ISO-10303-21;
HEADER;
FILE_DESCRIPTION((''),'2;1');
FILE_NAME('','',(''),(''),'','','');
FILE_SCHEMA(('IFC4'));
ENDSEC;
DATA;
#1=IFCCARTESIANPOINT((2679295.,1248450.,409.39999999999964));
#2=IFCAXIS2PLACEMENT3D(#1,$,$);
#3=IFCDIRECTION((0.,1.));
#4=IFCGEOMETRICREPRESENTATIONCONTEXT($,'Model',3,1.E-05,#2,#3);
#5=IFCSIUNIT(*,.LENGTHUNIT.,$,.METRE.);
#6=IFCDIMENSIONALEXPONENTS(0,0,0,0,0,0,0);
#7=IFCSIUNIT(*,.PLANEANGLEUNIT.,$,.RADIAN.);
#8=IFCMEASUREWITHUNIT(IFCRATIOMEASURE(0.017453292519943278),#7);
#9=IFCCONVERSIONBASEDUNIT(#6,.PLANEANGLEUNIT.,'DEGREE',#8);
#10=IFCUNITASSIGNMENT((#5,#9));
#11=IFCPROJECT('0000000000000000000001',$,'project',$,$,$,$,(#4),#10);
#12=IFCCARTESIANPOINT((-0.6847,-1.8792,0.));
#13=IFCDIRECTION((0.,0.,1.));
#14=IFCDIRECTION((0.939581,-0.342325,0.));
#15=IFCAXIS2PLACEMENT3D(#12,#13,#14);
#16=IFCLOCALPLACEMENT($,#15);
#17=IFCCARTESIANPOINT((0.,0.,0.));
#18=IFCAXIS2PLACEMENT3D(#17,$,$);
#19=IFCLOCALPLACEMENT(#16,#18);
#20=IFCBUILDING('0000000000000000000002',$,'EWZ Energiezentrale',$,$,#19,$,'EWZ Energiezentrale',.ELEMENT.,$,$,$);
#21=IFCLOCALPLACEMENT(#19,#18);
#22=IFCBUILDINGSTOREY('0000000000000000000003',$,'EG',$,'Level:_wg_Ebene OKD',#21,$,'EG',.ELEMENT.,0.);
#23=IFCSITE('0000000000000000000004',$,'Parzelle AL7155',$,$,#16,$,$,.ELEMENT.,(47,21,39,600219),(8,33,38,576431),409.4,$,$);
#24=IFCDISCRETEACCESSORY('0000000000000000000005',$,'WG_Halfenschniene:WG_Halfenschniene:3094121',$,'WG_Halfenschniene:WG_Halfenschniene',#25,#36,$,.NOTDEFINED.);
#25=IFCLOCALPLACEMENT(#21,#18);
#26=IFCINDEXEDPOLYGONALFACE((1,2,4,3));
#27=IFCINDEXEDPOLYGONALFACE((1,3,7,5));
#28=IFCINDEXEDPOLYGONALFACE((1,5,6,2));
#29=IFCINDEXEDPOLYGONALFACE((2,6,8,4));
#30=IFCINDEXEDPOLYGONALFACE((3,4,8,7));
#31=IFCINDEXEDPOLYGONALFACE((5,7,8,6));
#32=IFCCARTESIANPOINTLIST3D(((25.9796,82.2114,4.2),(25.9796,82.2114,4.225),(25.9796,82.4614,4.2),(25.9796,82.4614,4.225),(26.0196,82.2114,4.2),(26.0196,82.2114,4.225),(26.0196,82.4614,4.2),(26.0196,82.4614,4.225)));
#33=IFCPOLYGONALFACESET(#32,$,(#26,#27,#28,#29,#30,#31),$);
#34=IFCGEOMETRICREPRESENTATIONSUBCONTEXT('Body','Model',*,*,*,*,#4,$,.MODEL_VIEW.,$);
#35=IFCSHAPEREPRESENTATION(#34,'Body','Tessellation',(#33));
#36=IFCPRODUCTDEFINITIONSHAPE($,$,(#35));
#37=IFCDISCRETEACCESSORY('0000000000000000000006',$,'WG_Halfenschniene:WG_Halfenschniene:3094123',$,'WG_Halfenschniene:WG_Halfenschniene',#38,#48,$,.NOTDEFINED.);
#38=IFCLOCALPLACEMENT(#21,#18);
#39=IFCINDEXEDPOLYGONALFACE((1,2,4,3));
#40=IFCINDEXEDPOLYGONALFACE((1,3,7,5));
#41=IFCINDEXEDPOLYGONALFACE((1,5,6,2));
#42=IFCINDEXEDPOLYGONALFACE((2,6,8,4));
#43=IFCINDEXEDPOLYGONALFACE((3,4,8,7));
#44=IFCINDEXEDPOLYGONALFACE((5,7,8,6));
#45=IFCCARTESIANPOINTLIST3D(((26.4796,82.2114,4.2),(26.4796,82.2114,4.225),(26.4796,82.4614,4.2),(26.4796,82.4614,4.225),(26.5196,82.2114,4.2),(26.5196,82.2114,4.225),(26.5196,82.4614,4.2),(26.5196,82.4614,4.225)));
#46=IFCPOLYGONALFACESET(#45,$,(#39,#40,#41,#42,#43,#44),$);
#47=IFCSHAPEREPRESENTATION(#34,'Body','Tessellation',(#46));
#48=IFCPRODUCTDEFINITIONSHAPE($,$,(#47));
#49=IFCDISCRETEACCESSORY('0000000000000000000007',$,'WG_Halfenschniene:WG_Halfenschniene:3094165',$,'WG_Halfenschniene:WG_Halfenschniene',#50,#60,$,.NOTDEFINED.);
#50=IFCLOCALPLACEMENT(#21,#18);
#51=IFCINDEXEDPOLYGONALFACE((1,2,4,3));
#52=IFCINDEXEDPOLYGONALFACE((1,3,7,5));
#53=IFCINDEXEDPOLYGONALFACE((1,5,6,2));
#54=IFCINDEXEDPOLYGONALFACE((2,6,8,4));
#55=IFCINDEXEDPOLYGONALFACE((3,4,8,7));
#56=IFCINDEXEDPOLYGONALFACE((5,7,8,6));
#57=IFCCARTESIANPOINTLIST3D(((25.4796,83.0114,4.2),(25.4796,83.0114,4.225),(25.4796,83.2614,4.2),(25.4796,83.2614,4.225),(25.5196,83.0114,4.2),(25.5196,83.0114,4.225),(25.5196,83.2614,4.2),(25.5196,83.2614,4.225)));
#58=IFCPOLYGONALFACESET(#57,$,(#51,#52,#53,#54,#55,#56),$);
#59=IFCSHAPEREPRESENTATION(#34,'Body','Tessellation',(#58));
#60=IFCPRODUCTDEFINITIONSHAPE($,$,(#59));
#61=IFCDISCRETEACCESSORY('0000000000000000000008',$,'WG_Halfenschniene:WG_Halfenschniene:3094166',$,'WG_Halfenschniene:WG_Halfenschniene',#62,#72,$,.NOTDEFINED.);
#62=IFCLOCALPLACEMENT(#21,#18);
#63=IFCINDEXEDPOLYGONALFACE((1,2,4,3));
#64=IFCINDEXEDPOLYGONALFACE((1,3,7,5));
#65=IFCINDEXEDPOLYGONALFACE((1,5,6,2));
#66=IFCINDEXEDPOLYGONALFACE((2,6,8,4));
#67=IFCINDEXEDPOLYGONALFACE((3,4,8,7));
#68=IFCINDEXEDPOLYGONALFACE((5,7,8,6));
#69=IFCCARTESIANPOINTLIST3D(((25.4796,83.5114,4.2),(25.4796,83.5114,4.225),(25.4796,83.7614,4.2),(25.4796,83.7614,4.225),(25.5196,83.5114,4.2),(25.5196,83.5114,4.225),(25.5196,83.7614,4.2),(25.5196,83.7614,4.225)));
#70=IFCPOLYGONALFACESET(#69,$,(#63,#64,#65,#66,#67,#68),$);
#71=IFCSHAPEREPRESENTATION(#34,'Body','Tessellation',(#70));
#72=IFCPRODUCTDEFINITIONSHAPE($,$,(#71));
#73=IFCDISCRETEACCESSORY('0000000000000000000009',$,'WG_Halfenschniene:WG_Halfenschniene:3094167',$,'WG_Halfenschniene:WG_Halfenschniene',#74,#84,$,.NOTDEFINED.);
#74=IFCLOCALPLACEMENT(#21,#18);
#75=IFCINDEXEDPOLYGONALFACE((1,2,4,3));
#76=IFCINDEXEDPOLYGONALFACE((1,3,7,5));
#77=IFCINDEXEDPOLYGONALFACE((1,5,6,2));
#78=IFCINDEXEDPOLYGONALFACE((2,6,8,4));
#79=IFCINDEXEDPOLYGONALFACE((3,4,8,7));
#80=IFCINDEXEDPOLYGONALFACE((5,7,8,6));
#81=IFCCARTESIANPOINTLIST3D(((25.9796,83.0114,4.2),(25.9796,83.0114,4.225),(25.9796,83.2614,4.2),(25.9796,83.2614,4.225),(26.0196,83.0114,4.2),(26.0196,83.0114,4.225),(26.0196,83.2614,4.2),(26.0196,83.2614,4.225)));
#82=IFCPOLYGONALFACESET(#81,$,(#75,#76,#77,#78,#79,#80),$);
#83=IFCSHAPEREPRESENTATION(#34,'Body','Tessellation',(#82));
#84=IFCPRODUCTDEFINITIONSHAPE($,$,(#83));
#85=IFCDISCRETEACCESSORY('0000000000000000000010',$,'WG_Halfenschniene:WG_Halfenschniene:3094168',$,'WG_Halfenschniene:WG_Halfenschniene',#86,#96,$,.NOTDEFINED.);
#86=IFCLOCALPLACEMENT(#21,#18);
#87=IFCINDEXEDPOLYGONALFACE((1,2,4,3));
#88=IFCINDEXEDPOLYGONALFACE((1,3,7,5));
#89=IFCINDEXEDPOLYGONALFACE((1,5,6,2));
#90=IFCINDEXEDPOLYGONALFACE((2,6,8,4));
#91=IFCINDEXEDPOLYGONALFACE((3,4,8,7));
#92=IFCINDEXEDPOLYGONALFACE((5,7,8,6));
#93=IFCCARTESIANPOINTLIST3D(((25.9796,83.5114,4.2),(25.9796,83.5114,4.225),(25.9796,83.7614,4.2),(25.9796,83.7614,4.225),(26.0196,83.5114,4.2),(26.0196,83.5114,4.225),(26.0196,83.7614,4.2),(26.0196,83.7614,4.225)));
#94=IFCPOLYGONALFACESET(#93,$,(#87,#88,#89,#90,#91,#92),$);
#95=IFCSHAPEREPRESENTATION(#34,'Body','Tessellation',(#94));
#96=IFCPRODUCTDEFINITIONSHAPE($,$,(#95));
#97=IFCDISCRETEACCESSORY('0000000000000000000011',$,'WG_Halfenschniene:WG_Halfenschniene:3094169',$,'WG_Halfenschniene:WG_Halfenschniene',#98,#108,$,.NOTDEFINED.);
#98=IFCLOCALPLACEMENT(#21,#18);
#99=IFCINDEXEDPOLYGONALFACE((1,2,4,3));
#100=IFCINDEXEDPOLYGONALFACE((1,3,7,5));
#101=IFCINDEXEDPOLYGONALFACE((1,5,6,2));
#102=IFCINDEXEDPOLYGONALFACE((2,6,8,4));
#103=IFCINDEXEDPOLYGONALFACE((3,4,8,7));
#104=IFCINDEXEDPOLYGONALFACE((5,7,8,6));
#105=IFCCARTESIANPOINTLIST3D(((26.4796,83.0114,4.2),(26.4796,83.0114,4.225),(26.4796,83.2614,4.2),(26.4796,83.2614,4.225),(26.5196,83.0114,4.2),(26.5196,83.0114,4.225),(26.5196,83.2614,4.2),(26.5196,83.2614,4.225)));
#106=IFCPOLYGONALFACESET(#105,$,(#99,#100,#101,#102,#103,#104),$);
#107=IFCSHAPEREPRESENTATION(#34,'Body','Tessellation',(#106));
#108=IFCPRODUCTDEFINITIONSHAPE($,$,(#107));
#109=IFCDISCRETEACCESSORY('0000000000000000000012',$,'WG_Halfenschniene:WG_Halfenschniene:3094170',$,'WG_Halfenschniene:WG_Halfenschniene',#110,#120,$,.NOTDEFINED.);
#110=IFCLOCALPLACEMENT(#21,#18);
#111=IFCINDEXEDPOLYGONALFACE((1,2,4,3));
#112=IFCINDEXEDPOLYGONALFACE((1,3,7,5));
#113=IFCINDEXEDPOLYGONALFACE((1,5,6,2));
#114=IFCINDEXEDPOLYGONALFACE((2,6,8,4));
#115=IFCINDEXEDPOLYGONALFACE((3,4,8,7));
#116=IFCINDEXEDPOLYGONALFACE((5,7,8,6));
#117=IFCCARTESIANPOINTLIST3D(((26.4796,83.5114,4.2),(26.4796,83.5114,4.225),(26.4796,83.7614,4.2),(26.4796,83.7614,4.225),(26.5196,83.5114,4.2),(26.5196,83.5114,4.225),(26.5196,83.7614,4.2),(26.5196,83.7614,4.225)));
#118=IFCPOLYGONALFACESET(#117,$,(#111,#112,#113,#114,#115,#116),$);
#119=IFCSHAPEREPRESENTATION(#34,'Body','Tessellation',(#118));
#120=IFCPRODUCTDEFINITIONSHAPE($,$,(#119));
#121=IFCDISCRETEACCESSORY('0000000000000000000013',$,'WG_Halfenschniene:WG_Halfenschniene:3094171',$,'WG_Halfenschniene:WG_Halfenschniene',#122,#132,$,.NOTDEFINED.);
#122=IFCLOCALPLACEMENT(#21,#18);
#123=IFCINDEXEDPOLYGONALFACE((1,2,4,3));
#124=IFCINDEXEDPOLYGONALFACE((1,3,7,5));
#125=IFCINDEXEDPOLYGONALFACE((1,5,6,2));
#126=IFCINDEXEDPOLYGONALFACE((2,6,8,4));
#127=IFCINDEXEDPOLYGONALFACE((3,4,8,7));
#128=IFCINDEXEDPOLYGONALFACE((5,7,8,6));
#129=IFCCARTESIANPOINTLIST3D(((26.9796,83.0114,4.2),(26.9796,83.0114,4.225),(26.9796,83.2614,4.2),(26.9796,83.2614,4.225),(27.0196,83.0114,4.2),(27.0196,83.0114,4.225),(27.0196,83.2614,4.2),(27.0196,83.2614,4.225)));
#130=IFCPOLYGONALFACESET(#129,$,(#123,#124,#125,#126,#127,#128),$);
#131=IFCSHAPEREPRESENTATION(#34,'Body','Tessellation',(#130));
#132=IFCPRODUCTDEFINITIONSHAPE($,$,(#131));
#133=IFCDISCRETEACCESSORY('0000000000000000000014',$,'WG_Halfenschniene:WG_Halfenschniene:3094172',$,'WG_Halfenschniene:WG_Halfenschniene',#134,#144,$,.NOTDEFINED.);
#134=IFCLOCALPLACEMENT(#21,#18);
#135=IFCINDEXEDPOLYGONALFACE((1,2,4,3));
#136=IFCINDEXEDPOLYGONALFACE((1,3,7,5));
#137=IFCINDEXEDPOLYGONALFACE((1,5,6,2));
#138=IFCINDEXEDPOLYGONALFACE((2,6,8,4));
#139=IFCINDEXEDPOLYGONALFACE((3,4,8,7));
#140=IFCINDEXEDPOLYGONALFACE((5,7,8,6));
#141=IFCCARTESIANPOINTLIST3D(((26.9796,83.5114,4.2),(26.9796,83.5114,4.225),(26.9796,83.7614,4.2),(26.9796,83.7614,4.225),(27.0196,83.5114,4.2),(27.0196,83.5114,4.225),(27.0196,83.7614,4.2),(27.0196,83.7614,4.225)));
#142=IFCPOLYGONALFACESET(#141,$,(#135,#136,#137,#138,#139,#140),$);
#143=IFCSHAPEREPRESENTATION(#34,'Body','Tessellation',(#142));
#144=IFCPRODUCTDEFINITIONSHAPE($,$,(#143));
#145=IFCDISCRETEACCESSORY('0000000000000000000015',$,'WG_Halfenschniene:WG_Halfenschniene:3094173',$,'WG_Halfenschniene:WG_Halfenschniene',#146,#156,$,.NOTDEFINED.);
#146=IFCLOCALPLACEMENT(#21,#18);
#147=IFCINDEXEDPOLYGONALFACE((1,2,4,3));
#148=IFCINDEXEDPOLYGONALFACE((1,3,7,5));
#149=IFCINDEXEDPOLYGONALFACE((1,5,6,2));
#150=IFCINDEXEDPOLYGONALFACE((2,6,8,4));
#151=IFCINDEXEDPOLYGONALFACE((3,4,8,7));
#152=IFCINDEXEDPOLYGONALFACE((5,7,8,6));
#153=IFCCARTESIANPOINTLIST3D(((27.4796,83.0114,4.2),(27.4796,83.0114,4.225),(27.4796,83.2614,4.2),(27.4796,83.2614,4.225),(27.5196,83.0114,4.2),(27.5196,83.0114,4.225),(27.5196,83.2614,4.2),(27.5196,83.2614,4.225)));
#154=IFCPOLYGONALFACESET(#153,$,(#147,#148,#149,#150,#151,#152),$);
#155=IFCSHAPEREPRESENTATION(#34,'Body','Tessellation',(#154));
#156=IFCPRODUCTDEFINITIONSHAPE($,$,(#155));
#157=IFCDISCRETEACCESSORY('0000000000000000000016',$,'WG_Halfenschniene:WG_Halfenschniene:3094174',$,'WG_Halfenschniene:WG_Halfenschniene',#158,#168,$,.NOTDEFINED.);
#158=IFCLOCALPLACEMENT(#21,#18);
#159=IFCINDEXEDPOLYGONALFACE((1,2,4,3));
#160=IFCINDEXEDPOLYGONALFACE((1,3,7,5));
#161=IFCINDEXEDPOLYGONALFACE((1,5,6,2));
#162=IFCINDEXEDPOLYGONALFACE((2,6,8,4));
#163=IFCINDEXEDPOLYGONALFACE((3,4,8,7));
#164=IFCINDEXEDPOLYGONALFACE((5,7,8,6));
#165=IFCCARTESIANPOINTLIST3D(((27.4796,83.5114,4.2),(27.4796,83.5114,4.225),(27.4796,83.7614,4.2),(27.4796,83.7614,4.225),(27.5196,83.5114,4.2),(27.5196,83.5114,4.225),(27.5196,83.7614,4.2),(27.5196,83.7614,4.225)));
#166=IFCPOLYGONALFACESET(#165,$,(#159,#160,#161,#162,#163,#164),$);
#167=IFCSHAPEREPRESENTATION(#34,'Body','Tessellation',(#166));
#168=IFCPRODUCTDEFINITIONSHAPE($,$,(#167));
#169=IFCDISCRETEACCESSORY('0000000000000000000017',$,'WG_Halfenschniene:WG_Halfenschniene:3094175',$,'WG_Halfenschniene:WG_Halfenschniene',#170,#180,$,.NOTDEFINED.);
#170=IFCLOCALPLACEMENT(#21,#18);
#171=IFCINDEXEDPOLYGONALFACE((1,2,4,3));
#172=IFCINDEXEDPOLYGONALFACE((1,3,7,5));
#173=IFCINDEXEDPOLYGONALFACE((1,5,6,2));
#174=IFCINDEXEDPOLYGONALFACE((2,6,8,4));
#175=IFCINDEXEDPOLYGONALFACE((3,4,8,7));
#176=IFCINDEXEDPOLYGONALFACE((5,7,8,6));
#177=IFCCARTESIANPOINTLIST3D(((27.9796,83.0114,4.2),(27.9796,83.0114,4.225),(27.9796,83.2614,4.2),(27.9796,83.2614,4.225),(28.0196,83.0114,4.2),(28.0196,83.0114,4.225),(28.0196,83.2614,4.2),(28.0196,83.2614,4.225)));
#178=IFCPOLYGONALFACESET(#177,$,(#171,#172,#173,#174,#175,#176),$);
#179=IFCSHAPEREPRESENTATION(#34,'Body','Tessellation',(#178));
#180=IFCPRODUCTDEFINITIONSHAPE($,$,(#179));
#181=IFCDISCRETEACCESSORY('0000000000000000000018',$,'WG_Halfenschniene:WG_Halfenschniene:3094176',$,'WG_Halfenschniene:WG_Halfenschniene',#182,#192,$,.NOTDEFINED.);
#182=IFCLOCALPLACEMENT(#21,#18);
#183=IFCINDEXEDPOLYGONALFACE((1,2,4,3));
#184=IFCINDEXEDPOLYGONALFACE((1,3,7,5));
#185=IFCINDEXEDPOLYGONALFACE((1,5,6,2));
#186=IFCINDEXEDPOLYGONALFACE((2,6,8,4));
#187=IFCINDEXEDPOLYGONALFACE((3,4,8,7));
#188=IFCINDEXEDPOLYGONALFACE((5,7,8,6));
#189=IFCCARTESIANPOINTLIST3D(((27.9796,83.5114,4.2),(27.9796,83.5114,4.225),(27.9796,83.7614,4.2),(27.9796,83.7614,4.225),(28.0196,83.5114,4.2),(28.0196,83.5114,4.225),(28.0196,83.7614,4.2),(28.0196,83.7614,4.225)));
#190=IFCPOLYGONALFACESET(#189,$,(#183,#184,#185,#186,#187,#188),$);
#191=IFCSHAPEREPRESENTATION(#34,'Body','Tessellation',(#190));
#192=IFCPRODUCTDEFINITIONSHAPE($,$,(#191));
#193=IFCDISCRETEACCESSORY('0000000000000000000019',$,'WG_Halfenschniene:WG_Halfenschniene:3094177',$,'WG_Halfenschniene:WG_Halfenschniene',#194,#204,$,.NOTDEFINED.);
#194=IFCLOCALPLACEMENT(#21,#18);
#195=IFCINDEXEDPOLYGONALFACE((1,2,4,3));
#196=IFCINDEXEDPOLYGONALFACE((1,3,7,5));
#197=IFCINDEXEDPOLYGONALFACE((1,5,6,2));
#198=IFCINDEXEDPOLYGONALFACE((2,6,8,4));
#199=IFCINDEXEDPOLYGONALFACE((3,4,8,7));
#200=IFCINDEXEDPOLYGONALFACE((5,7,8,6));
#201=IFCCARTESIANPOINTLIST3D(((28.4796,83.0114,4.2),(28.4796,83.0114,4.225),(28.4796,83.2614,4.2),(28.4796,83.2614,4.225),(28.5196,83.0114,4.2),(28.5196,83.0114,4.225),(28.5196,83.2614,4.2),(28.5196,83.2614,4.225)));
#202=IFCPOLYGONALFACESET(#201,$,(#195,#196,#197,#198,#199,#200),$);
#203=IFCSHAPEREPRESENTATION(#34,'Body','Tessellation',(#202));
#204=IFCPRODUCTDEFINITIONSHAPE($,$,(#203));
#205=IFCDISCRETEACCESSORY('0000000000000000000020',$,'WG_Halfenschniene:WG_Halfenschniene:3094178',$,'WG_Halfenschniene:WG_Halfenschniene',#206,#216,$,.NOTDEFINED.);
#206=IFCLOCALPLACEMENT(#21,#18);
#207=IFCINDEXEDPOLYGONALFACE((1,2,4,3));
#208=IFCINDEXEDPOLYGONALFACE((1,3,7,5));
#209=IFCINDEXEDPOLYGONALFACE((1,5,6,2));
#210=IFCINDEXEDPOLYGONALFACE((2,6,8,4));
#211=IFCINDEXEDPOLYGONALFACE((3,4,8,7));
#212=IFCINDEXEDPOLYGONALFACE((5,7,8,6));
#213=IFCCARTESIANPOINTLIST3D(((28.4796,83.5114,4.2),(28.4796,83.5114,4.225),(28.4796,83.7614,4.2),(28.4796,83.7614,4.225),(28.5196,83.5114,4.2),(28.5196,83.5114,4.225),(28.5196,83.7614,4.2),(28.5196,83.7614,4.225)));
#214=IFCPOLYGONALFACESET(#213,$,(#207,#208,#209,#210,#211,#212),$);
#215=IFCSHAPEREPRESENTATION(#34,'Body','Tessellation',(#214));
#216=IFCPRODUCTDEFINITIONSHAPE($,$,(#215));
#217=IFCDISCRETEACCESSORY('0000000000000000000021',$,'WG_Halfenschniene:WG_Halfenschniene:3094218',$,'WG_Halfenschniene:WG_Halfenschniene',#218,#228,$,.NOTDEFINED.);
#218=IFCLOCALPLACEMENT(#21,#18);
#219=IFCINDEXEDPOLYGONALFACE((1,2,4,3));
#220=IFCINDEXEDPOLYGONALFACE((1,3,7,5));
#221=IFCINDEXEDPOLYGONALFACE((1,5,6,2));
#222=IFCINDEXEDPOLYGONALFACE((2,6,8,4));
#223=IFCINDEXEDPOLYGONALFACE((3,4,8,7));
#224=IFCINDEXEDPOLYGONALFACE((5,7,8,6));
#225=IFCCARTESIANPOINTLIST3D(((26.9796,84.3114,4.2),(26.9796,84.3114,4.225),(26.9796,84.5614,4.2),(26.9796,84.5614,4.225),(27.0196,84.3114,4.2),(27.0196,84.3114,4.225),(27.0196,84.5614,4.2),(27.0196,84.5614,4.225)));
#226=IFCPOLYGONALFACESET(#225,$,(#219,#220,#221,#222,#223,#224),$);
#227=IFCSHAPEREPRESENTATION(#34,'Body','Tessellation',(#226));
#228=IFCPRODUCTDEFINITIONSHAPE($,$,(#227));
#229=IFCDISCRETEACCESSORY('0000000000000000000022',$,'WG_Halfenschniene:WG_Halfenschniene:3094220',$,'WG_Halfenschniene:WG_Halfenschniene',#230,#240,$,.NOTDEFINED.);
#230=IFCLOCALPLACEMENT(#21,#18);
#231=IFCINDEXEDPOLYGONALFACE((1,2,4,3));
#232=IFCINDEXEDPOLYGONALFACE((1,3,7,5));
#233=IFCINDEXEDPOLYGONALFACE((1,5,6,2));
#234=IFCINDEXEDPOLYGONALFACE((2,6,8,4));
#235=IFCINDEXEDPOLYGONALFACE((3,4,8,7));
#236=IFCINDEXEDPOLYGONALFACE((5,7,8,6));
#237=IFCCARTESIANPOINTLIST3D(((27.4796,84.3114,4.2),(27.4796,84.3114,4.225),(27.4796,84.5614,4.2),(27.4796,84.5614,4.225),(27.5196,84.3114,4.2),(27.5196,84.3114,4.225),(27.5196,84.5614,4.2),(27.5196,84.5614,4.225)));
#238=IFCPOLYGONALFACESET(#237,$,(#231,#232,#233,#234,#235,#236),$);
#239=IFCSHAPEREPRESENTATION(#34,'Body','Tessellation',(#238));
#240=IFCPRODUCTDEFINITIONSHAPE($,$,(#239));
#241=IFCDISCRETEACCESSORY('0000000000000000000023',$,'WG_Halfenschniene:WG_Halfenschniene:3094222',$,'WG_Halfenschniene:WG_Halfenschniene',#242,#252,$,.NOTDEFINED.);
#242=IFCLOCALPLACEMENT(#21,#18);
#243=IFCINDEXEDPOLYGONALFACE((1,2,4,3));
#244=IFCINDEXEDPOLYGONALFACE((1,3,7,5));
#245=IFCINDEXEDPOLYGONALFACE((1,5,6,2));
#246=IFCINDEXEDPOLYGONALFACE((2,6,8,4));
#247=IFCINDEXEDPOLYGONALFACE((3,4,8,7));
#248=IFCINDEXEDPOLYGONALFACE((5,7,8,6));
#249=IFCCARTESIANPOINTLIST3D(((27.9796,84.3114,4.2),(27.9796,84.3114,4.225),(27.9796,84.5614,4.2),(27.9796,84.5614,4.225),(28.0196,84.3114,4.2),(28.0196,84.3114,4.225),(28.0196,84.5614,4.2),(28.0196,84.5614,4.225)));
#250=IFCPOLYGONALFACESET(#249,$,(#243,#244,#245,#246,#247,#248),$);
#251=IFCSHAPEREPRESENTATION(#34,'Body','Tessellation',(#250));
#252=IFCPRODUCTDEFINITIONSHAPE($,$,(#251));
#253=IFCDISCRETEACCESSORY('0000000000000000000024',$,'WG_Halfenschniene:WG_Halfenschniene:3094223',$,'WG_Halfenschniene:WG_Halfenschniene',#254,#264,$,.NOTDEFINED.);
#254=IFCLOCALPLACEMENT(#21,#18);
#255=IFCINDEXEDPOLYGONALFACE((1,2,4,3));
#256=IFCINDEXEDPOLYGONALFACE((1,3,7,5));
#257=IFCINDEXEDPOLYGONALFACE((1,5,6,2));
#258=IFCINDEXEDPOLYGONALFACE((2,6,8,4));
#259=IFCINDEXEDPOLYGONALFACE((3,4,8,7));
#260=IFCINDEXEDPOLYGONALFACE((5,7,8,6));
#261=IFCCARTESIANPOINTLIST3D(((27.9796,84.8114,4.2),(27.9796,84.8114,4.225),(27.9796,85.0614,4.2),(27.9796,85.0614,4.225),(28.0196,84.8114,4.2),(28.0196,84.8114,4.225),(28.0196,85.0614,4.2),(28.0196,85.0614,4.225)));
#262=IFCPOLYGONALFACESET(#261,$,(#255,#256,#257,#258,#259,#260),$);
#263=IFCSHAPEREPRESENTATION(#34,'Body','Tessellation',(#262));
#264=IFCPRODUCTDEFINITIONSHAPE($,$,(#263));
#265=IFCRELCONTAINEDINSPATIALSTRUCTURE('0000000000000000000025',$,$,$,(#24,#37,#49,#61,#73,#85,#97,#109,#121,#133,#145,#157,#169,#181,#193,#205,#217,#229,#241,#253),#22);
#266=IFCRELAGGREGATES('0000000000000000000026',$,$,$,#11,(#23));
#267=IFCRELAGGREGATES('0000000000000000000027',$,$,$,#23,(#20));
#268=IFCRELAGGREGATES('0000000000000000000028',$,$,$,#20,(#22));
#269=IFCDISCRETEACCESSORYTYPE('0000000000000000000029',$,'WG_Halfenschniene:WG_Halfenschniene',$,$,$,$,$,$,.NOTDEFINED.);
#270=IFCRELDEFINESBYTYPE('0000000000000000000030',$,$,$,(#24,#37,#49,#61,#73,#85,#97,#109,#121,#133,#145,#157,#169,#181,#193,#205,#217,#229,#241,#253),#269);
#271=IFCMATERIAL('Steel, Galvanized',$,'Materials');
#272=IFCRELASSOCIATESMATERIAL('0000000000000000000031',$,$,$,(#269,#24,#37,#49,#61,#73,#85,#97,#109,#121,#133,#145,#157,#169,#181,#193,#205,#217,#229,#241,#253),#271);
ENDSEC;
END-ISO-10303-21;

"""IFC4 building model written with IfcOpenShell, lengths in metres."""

from ifc_helpers import new_model, entity, si_unit, converted_unit, direction, frame, origin, place, context, subcontext, project, spatial, indexed_curve, outline, extrude, source, transform, mapped, material, type_object, element, save


model = new_model("IFC4")

# Units and contexts
model_context = context("Model", 3, precision=1e-05, world=frame((2679295.0, 1248450.0, 409.39999999999964)), true_north=direction((0.0, 1.0)))
body_context = subcontext(model_context, "Body", "Model", "MODEL_VIEW")
ifc_project = project(units=[si_unit("LENGTHUNIT", "METRE"), converted_unit("PLANEANGLEUNIT", "DEGREE", entity("IfcRatioMeasure", 0.017453292519943278), si_unit("PLANEANGLEUNIT", "RADIAN"), dimensions=[0, 0, 0, 0, 0, 0, 0])], contexts=[model_context])

# Site, building, storey
site_placement = place(None, frame((-0.6847, -1.8792, 0.0), z_axis=(0.0, 0.0, 1.0), x_axis=(0.939581, -0.342325, 0.0)))
site = spatial("IfcSite", under=ifc_project, at=site_placement, Name="Parzelle AL7155", CompositionType="ELEMENT", RefLatitude=(47, 21, 39, 600219), RefLongitude=(8, 33, 38, 576431), RefElevation=409.4)
building_placement = place(site_placement, origin())
building = spatial("IfcBuilding", under=site, at=building_placement, Name="EWZ Energiezentrale", LongName="EWZ Energiezentrale", CompositionType="ELEMENT")
storey_placement = place(building_placement, origin())
storey = spatial("IfcBuildingStorey", under=building, at=storey_placement, Name="EG", ObjectType="Level:_wg_Ebene OKD", LongName="EG", CompositionType="ELEMENT", Elevation=0.0)

# Discrete accessories
ifc_material = material(Name="Steel, Galvanized", Category="Materials")
discrete_accessory_type = type_object("IfcDiscreteAccessoryType", Name="WG_Halfenschniene:WG_Halfenschniene", PredefinedType="NOTDEFINED", material=ifc_material)
shared_shape = source(origin(), body_context, "Body", "SweptSolid", [
    extrude(outline(indexed_curve([(-0.125, -0.02), (0.125, -0.02), (0.125, 0.02), (-0.125, 0.02), (-0.125, -0.02)], self_intersect=False)), frame((0.125, 0.0, -0.0125)), (0.0, 0.0, 1.0), 0.025),
])
for number, where, z_axis, x_axis, name in (
    (1, (25.9996, 82.2114, 4.2125), (0.0, 0.0, -1.0), (0.0, 1.0, 0.0), "WG_Halfenschniene:WG_Halfenschniene:3094121"),
    (2, (26.4996, 82.2114, 4.2125), (0.0, 0.0, -1.0), (0.0, 1.0, 0.0), "WG_Halfenschniene:WG_Halfenschniene:3094123"),
    (3, (25.4996, 83.0114, 4.2125), (0.0, 0.0, -1.0), (0.0, 1.0, 0.0), "WG_Halfenschniene:WG_Halfenschniene:3094165"),
    (4, (25.4996, 83.5114, 4.2125), (0.0, 0.0, -1.0), (0.0, 1.0, 0.0), "WG_Halfenschniene:WG_Halfenschniene:3094166"),
    (5, (25.9996, 83.0114, 4.2125), (0.0, 0.0, -1.0), (0.0, 1.0, 0.0), "WG_Halfenschniene:WG_Halfenschniene:3094167"),
    (6, (25.9996, 83.5114, 4.2125), (0.0, 0.0, -1.0), (0.0, 1.0, 0.0), "WG_Halfenschniene:WG_Halfenschniene:3094168"),
    (7, (26.4996, 83.0114, 4.2125), (0.0, 0.0, -1.0), (0.0, 1.0, 0.0), "WG_Halfenschniene:WG_Halfenschniene:3094169"),
    (8, (26.4996, 83.5114, 4.2125), (0.0, 0.0, -1.0), (0.0, 1.0, 0.0), "WG_Halfenschniene:WG_Halfenschniene:3094170"),
    (9, (26.9996, 83.0114, 4.2125), (0.0, 0.0, -1.0), (0.0, 1.0, 0.0), "WG_Halfenschniene:WG_Halfenschniene:3094171"),
    (10, (26.9996, 83.5114, 4.2125), (0.0, 0.0, -1.0), (0.0, 1.0, 0.0), "WG_Halfenschniene:WG_Halfenschniene:3094172"),
    (11, (27.4996, 83.0114, 4.2125), (0.0, 0.0, -1.0), (0.0, 1.0, 0.0), "WG_Halfenschniene:WG_Halfenschniene:3094173"),
    (12, (27.4996, 83.5114, 4.2125), (0.0, 0.0, -1.0), (0.0, 1.0, 0.0), "WG_Halfenschniene:WG_Halfenschniene:3094174"),
    (13, (27.9996, 83.0114, 4.2125), (0.0, 0.0, -1.0), (0.0, 1.0, 0.0), "WG_Halfenschniene:WG_Halfenschniene:3094175"),
    (14, (27.9996, 83.5114, 4.2125), (0.0, 0.0, -1.0), (0.0, 1.0, 0.0), "WG_Halfenschniene:WG_Halfenschniene:3094176"),
    (15, (28.4996, 83.0114, 4.2125), (0.0, 0.0, -1.0), (0.0, 1.0, 0.0), "WG_Halfenschniene:WG_Halfenschniene:3094177"),
    (16, (28.4996, 83.5114, 4.2125), (0.0, 0.0, -1.0), (0.0, 1.0, 0.0), "WG_Halfenschniene:WG_Halfenschniene:3094178"),
    (17, (26.9996, 84.3114, 4.2125), (0.0, 0.0, -1.0), (0.0, 1.0, 0.0), "WG_Halfenschniene:WG_Halfenschniene:3094218"),
    (18, (27.4996, 84.3114, 4.2125), (0.0, 0.0, -1.0), (0.0, 1.0, 0.0), "WG_Halfenschniene:WG_Halfenschniene:3094220"),
    (19, (27.9996, 84.3114, 4.2125), (0.0, 0.0, -1.0), (0.0, 1.0, 0.0), "WG_Halfenschniene:WG_Halfenschniene:3094222"),
    (20, (27.9996, 84.8114, 4.2125), (0.0, 0.0, -1.0), (0.0, 1.0, 0.0), "WG_Halfenschniene:WG_Halfenschniene:3094223"),
):
    element("IfcDiscreteAccessory", number, at=place(storey_placement, frame(where, z_axis=z_axis, x_axis=x_axis)), inside=storey, type_object=discrete_accessory_type, material=ifc_material, Name=name, ObjectType="WG_Halfenschniene:WG_Halfenschniene", PredefinedType="NOTDEFINED", context=body_context, shape_type="MappedRepresentation", body=[
        mapped(shared_shape, transform((0.0, 0.0, 0.0), scale=1.0)),
    ])

save(model, "model.ifc")
